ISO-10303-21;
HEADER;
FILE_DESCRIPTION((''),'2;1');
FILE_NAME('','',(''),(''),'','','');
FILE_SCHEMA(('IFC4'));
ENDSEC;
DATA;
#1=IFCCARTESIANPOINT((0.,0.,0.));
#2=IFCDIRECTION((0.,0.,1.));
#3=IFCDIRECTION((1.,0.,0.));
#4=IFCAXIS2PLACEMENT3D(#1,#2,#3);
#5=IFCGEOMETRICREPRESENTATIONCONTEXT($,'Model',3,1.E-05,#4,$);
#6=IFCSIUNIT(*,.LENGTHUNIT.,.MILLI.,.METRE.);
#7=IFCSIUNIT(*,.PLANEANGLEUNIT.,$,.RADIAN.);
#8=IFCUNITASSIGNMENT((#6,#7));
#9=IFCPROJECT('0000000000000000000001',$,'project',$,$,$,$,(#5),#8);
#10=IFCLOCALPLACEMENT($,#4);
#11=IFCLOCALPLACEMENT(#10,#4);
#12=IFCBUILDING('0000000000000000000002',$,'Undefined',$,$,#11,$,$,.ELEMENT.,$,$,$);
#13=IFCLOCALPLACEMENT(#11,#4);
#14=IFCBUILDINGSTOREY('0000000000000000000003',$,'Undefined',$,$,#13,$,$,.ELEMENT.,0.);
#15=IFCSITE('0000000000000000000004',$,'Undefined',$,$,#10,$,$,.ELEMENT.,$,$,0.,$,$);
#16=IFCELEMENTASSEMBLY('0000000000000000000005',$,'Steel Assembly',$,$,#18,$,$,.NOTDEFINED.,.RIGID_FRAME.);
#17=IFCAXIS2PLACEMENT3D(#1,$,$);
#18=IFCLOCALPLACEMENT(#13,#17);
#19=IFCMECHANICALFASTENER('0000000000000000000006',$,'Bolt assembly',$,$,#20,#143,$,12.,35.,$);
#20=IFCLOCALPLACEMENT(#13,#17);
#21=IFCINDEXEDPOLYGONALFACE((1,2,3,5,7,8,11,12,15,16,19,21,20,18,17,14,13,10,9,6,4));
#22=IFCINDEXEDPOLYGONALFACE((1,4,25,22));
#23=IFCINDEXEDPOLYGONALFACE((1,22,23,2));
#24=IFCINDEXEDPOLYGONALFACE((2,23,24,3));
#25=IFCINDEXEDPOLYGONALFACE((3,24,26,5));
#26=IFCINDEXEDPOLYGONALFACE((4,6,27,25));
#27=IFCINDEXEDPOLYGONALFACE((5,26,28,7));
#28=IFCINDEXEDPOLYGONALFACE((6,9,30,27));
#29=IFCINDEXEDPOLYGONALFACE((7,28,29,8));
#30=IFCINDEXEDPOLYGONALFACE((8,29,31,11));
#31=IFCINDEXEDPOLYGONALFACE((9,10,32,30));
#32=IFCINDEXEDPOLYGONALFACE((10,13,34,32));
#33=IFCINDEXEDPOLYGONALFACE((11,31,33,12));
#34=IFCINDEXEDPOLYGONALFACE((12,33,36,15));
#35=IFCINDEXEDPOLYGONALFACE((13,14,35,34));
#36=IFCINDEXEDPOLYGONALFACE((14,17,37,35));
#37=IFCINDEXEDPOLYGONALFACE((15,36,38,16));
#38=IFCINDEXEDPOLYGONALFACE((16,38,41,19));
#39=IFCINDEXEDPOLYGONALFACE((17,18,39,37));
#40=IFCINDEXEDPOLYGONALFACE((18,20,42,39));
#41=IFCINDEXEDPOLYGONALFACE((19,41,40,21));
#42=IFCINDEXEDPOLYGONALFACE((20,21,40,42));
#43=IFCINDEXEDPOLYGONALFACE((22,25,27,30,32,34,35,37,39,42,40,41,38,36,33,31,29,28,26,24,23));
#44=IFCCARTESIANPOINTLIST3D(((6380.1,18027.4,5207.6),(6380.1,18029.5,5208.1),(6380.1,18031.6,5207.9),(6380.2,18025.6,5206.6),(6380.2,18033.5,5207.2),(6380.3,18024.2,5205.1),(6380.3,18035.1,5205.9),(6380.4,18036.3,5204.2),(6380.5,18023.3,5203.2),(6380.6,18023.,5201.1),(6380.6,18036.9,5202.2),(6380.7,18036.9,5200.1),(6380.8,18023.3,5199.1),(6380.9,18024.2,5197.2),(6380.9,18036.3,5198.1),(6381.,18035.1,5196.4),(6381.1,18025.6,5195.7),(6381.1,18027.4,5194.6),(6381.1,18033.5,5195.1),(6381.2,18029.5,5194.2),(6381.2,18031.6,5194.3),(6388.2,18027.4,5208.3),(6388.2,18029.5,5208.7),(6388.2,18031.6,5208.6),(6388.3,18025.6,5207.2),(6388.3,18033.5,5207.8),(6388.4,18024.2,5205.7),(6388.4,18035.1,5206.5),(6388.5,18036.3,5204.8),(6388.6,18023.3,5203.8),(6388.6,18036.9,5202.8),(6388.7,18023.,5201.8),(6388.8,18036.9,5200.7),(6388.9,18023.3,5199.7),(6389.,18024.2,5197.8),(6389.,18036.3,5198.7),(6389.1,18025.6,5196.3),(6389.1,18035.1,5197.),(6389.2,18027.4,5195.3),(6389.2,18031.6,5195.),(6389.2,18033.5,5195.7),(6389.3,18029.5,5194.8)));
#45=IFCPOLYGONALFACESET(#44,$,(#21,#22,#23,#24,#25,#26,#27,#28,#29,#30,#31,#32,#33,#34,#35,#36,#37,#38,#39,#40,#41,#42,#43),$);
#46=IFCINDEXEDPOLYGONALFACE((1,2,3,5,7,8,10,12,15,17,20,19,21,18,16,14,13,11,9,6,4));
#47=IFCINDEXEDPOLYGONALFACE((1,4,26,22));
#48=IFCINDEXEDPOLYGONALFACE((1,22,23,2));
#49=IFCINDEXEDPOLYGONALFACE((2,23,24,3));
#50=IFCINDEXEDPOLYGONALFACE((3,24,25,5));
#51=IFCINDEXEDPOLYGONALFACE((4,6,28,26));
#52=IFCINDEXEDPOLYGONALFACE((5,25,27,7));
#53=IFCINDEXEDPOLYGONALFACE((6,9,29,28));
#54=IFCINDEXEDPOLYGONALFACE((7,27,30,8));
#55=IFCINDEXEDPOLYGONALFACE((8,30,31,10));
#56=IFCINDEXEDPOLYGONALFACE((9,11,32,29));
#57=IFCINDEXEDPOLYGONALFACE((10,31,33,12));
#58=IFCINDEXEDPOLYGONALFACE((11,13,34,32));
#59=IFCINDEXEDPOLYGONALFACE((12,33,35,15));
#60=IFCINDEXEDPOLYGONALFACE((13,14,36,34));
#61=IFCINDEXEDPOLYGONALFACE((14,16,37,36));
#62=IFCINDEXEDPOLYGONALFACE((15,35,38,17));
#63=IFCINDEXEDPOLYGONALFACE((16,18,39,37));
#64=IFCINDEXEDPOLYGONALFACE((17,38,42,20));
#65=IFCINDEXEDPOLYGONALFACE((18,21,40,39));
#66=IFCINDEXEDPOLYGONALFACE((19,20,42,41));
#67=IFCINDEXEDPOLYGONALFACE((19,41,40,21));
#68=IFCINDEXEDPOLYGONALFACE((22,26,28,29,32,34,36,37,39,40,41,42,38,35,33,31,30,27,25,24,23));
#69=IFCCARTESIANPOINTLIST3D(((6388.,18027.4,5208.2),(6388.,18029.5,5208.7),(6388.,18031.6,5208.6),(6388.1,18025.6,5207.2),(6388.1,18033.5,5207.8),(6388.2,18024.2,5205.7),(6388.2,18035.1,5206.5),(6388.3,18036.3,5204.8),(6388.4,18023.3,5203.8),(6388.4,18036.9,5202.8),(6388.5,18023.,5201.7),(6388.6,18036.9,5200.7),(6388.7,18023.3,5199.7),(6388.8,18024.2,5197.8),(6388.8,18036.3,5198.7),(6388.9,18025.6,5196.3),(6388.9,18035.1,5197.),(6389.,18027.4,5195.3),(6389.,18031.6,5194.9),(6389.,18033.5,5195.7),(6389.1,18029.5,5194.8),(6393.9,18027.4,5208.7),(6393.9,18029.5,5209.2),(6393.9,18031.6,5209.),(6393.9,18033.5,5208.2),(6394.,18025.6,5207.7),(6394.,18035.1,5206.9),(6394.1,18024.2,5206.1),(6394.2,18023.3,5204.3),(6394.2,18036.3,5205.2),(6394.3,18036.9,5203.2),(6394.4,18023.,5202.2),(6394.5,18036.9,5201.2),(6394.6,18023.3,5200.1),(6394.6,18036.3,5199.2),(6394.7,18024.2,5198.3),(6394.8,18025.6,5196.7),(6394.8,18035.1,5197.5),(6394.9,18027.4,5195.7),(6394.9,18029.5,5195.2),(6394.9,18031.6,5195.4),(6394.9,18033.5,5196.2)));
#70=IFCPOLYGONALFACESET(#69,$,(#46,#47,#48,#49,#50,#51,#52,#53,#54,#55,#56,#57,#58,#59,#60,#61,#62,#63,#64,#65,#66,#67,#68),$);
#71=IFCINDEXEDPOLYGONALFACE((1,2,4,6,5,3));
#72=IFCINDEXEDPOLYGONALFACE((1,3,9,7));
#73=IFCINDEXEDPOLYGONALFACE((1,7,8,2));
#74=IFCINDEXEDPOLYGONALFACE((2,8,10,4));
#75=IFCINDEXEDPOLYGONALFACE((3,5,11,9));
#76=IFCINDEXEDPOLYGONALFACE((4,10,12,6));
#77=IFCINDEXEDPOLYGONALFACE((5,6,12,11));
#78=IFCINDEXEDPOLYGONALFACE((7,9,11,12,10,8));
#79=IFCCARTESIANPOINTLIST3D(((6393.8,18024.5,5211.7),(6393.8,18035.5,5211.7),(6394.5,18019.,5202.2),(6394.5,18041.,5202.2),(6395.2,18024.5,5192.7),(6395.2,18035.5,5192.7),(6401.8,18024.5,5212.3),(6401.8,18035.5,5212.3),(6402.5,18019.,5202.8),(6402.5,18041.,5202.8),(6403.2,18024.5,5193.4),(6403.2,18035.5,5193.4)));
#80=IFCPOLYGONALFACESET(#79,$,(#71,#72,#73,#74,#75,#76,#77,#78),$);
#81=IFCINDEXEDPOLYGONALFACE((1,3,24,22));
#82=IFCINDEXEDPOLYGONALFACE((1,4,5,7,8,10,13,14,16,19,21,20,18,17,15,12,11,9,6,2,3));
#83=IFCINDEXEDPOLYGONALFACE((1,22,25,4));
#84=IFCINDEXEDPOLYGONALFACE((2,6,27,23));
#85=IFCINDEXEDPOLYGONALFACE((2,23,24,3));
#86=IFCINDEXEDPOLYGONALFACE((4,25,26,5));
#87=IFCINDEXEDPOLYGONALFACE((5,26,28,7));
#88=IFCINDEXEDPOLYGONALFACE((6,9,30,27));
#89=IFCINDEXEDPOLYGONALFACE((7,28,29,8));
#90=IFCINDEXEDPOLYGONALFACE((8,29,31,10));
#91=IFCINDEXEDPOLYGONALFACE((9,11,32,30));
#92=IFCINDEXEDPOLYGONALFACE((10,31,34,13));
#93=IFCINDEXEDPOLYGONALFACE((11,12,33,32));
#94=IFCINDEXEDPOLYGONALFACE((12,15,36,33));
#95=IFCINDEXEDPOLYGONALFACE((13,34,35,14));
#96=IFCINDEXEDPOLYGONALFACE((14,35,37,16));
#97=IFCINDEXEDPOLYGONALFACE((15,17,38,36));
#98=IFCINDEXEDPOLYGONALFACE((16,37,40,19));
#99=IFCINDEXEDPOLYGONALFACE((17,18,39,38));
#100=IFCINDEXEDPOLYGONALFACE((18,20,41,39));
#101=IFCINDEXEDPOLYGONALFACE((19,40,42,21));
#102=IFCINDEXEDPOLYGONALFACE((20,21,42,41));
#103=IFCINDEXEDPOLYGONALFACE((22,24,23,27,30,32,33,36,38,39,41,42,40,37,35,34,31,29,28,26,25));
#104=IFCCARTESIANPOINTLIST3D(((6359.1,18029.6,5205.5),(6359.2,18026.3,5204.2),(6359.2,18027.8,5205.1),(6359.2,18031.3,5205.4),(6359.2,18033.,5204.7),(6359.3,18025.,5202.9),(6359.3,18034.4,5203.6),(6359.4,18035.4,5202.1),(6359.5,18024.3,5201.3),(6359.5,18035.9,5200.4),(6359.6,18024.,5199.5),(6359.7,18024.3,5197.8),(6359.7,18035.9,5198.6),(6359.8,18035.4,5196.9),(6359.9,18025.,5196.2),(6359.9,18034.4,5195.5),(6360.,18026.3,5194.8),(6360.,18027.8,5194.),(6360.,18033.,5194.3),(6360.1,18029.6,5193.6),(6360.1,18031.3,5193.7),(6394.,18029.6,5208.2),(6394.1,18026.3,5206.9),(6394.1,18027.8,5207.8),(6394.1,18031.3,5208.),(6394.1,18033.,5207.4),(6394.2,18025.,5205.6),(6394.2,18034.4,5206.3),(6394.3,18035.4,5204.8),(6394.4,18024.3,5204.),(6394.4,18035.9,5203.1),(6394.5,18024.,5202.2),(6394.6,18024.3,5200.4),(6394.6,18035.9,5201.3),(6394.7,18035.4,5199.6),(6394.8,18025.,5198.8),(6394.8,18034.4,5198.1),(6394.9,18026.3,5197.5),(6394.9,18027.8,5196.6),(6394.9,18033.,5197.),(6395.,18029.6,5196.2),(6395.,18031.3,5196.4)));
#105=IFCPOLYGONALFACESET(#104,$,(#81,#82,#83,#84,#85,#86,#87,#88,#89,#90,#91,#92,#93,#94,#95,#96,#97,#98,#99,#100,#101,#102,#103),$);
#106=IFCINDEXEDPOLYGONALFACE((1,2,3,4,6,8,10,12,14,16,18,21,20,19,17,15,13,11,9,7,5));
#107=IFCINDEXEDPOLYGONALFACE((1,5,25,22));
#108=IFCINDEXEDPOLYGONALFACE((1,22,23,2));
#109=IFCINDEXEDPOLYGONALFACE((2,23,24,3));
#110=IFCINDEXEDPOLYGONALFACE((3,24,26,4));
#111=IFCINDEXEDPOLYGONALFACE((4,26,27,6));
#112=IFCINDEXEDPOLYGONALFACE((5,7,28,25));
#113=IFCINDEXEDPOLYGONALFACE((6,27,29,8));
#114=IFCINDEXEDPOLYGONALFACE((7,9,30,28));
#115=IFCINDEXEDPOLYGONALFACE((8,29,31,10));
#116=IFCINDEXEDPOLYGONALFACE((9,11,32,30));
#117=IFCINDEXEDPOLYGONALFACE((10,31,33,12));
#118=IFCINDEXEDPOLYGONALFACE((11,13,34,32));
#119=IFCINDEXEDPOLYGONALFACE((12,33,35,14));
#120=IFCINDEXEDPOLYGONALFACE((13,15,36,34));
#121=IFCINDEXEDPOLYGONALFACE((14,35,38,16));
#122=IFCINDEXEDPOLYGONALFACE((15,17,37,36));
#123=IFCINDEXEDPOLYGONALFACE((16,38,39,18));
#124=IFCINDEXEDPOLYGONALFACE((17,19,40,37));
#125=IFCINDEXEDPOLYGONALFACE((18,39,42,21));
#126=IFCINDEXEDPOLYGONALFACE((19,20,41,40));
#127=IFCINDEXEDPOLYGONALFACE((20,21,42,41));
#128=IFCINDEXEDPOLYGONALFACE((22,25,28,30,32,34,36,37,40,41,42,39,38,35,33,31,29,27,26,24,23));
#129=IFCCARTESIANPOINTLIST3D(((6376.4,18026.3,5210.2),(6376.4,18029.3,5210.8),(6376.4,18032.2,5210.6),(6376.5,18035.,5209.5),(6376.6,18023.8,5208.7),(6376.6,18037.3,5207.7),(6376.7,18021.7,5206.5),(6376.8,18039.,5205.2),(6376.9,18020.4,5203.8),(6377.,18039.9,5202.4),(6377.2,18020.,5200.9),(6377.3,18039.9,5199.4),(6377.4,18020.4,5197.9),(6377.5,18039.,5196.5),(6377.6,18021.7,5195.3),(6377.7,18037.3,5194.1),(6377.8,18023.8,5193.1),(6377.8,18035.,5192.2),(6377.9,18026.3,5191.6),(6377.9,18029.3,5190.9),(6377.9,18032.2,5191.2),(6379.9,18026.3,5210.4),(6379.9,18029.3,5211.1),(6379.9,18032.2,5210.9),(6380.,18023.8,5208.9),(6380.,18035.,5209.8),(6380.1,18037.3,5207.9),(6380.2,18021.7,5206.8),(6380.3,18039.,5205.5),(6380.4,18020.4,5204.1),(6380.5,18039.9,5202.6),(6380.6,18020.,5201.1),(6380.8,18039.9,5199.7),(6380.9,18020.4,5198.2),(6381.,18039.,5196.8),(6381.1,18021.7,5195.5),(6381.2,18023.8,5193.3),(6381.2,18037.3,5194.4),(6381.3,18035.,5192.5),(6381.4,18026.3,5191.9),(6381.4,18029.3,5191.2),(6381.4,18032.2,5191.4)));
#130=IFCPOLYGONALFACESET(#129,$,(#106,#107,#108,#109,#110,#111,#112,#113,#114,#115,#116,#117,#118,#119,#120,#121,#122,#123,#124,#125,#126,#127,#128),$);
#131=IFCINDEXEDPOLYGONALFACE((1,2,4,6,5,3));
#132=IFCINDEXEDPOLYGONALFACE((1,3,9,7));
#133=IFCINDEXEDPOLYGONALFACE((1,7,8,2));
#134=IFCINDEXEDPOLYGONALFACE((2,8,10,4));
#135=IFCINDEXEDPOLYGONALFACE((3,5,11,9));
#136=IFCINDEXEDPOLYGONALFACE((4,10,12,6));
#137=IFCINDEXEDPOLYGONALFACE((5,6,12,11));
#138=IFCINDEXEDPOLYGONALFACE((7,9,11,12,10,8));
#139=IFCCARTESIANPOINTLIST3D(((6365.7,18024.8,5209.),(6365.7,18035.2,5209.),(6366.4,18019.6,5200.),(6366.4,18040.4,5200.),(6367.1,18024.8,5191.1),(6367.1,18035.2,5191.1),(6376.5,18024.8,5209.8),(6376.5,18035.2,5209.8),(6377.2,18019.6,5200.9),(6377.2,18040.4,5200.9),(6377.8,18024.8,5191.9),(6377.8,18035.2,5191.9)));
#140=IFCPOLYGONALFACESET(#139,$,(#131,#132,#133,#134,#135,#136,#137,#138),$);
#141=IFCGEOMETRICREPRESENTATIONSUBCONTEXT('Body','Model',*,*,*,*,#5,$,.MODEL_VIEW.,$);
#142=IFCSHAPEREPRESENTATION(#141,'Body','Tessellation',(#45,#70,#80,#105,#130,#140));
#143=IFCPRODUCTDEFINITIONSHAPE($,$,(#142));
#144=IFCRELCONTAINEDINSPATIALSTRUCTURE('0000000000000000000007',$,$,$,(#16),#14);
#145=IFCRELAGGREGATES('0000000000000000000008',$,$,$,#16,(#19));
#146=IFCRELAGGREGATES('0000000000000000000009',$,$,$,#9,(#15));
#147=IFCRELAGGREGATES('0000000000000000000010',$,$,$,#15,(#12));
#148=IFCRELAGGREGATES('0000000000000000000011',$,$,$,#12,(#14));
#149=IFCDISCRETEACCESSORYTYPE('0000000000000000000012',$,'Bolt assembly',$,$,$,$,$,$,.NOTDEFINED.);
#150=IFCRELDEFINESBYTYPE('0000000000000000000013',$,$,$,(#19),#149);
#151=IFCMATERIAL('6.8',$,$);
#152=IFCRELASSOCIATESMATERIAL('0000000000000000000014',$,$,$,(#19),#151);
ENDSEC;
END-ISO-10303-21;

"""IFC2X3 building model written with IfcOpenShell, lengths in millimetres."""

from ifc_helpers import new_model, si_unit, frame, origin_with_axes, origin_2d_with_axis, place, context, subcontext, project, spatial, polyline, circle, outline, extrude, source, transform, mapped, material, type_object, element, aggregate, save


model = new_model("IFC2X3")

# Units and contexts
model_context = context("Model", 3, precision=1e-05, world=origin_with_axes())
body_context = subcontext(model_context, "Body", "Model", "MODEL_VIEW")
ifc_project = project(units=[si_unit("LENGTHUNIT", "METRE", prefix="MILLI"), si_unit("PLANEANGLEUNIT", "RADIAN")], contexts=[model_context])

# Site, building, storey
site_placement = place(None, origin_with_axes())
site = spatial("IfcSite", under=ifc_project, at=site_placement, Name="Undefined", CompositionType="ELEMENT", RefElevation=0.0)
building_placement = place(site_placement, origin_with_axes())
building = spatial("IfcBuilding", under=site, at=building_placement, Name="Undefined", CompositionType="ELEMENT")
storey_placement = place(building_placement, origin_with_axes())
storey = spatial("IfcBuildingStorey", under=building, at=storey_placement, Name="Undefined", CompositionType="ELEMENT", Elevation=0.0)

# Shared definitions
ifc_material_1 = material(Name="6.8")
discrete_accessory_type_1 = type_object("IfcDiscreteAccessoryType", Name="Bolt assembly")

# Element assembly, mechanical fastener
assembly_1_placement = place(storey_placement, origin_with_axes())
assembly_1 = element("IfcElementAssembly", 1, at=assembly_1_placement, inside=storey, Name="Steel Assembly", AssemblyPlace="NOTDEFINED", PredefinedType="RIGID_FRAME")
shared_shape_1 = source(origin_with_axes(), body_context, "Body", "SweptSolid", [
    extrude(circle(Radius=7.0, at=origin_2d_with_axis()), frame((0.0, 2.9, 0.0), z_axis=(0.0, 1.0, 0.0), x_axis=(1.0, 0.0, 0.0)), (0.0, 0.0, 1.0), 8.1),
    extrude(circle(Radius=7.0, at=origin_2d_with_axis()), frame((0.0, -2.9, 0.0), z_axis=(0.0, 1.0, 0.0), x_axis=(1.0, 0.0, 0.0)), (0.0, 0.0, 1.0), 5.9),
    extrude(outline(polyline([(11.0, 0.0), (5.5, 9.5), (-5.5, 9.5), (-11.0, 0.0), (-5.5, -9.5), (5.5, -9.5), (11.0, 0.0)])), frame((0.0, -11.0, 0.0), z_axis=(0.0, 1.0, 0.0), x_axis=(1.0, 0.0, 0.0)), (0.0, 0.0, 1.0), 8.0),
    extrude(circle(Radius=6.0, at=origin_2d_with_axis()), frame((0.0, -3.0, 0.0), z_axis=(0.0, 1.0, 0.0), x_axis=(1.0, 0.0, 0.0)), (0.0, 0.0, 1.0), 35.0),
    extrude(circle(Radius=10.0, at=origin_2d_with_axis()), frame((0.0, 11.0, 0.0), z_axis=(0.0, 1.0, 0.0), x_axis=(1.0, 0.0, 0.0)), (0.0, 0.0, 1.0), 3.5),
    extrude(outline(polyline([(10.4, 0.0), (5.2, 9.0), (-5.2, 9.0), (-10.4, 0.0), (-5.2, -9.0), (5.2, -9.0), (10.4, 0.0)])), frame((0.0, 14.5, 0.0), z_axis=(0.0, 1.0, 0.0), x_axis=(1.0, 0.0, 0.0)), (0.0, 0.0, 1.0), 10.8),
])
mechanical_fastener_1_placement = place(assembly_1_placement, frame((6391.6, 18030.0, 5202.0), z_axis=(0.076696, 0.0, -0.997054), x_axis=(0.0, -1.0, 0.0)))
mechanical_fastener_1 = element("IfcMechanicalFastener", 2, at=mechanical_fastener_1_placement, type_object=discrete_accessory_type_1, material=ifc_material_1, Name="Bolt assembly", NominalDiameter=12.0, NominalLength=35.0, context=body_context, shape_type="MappedRepresentation", body=[
    mapped(shared_shape_1, transform((0.0, 0.0, 0.0))),
])
aggregate(assembly_1, [mechanical_fastener_1])

save(model, "model.ifc")
